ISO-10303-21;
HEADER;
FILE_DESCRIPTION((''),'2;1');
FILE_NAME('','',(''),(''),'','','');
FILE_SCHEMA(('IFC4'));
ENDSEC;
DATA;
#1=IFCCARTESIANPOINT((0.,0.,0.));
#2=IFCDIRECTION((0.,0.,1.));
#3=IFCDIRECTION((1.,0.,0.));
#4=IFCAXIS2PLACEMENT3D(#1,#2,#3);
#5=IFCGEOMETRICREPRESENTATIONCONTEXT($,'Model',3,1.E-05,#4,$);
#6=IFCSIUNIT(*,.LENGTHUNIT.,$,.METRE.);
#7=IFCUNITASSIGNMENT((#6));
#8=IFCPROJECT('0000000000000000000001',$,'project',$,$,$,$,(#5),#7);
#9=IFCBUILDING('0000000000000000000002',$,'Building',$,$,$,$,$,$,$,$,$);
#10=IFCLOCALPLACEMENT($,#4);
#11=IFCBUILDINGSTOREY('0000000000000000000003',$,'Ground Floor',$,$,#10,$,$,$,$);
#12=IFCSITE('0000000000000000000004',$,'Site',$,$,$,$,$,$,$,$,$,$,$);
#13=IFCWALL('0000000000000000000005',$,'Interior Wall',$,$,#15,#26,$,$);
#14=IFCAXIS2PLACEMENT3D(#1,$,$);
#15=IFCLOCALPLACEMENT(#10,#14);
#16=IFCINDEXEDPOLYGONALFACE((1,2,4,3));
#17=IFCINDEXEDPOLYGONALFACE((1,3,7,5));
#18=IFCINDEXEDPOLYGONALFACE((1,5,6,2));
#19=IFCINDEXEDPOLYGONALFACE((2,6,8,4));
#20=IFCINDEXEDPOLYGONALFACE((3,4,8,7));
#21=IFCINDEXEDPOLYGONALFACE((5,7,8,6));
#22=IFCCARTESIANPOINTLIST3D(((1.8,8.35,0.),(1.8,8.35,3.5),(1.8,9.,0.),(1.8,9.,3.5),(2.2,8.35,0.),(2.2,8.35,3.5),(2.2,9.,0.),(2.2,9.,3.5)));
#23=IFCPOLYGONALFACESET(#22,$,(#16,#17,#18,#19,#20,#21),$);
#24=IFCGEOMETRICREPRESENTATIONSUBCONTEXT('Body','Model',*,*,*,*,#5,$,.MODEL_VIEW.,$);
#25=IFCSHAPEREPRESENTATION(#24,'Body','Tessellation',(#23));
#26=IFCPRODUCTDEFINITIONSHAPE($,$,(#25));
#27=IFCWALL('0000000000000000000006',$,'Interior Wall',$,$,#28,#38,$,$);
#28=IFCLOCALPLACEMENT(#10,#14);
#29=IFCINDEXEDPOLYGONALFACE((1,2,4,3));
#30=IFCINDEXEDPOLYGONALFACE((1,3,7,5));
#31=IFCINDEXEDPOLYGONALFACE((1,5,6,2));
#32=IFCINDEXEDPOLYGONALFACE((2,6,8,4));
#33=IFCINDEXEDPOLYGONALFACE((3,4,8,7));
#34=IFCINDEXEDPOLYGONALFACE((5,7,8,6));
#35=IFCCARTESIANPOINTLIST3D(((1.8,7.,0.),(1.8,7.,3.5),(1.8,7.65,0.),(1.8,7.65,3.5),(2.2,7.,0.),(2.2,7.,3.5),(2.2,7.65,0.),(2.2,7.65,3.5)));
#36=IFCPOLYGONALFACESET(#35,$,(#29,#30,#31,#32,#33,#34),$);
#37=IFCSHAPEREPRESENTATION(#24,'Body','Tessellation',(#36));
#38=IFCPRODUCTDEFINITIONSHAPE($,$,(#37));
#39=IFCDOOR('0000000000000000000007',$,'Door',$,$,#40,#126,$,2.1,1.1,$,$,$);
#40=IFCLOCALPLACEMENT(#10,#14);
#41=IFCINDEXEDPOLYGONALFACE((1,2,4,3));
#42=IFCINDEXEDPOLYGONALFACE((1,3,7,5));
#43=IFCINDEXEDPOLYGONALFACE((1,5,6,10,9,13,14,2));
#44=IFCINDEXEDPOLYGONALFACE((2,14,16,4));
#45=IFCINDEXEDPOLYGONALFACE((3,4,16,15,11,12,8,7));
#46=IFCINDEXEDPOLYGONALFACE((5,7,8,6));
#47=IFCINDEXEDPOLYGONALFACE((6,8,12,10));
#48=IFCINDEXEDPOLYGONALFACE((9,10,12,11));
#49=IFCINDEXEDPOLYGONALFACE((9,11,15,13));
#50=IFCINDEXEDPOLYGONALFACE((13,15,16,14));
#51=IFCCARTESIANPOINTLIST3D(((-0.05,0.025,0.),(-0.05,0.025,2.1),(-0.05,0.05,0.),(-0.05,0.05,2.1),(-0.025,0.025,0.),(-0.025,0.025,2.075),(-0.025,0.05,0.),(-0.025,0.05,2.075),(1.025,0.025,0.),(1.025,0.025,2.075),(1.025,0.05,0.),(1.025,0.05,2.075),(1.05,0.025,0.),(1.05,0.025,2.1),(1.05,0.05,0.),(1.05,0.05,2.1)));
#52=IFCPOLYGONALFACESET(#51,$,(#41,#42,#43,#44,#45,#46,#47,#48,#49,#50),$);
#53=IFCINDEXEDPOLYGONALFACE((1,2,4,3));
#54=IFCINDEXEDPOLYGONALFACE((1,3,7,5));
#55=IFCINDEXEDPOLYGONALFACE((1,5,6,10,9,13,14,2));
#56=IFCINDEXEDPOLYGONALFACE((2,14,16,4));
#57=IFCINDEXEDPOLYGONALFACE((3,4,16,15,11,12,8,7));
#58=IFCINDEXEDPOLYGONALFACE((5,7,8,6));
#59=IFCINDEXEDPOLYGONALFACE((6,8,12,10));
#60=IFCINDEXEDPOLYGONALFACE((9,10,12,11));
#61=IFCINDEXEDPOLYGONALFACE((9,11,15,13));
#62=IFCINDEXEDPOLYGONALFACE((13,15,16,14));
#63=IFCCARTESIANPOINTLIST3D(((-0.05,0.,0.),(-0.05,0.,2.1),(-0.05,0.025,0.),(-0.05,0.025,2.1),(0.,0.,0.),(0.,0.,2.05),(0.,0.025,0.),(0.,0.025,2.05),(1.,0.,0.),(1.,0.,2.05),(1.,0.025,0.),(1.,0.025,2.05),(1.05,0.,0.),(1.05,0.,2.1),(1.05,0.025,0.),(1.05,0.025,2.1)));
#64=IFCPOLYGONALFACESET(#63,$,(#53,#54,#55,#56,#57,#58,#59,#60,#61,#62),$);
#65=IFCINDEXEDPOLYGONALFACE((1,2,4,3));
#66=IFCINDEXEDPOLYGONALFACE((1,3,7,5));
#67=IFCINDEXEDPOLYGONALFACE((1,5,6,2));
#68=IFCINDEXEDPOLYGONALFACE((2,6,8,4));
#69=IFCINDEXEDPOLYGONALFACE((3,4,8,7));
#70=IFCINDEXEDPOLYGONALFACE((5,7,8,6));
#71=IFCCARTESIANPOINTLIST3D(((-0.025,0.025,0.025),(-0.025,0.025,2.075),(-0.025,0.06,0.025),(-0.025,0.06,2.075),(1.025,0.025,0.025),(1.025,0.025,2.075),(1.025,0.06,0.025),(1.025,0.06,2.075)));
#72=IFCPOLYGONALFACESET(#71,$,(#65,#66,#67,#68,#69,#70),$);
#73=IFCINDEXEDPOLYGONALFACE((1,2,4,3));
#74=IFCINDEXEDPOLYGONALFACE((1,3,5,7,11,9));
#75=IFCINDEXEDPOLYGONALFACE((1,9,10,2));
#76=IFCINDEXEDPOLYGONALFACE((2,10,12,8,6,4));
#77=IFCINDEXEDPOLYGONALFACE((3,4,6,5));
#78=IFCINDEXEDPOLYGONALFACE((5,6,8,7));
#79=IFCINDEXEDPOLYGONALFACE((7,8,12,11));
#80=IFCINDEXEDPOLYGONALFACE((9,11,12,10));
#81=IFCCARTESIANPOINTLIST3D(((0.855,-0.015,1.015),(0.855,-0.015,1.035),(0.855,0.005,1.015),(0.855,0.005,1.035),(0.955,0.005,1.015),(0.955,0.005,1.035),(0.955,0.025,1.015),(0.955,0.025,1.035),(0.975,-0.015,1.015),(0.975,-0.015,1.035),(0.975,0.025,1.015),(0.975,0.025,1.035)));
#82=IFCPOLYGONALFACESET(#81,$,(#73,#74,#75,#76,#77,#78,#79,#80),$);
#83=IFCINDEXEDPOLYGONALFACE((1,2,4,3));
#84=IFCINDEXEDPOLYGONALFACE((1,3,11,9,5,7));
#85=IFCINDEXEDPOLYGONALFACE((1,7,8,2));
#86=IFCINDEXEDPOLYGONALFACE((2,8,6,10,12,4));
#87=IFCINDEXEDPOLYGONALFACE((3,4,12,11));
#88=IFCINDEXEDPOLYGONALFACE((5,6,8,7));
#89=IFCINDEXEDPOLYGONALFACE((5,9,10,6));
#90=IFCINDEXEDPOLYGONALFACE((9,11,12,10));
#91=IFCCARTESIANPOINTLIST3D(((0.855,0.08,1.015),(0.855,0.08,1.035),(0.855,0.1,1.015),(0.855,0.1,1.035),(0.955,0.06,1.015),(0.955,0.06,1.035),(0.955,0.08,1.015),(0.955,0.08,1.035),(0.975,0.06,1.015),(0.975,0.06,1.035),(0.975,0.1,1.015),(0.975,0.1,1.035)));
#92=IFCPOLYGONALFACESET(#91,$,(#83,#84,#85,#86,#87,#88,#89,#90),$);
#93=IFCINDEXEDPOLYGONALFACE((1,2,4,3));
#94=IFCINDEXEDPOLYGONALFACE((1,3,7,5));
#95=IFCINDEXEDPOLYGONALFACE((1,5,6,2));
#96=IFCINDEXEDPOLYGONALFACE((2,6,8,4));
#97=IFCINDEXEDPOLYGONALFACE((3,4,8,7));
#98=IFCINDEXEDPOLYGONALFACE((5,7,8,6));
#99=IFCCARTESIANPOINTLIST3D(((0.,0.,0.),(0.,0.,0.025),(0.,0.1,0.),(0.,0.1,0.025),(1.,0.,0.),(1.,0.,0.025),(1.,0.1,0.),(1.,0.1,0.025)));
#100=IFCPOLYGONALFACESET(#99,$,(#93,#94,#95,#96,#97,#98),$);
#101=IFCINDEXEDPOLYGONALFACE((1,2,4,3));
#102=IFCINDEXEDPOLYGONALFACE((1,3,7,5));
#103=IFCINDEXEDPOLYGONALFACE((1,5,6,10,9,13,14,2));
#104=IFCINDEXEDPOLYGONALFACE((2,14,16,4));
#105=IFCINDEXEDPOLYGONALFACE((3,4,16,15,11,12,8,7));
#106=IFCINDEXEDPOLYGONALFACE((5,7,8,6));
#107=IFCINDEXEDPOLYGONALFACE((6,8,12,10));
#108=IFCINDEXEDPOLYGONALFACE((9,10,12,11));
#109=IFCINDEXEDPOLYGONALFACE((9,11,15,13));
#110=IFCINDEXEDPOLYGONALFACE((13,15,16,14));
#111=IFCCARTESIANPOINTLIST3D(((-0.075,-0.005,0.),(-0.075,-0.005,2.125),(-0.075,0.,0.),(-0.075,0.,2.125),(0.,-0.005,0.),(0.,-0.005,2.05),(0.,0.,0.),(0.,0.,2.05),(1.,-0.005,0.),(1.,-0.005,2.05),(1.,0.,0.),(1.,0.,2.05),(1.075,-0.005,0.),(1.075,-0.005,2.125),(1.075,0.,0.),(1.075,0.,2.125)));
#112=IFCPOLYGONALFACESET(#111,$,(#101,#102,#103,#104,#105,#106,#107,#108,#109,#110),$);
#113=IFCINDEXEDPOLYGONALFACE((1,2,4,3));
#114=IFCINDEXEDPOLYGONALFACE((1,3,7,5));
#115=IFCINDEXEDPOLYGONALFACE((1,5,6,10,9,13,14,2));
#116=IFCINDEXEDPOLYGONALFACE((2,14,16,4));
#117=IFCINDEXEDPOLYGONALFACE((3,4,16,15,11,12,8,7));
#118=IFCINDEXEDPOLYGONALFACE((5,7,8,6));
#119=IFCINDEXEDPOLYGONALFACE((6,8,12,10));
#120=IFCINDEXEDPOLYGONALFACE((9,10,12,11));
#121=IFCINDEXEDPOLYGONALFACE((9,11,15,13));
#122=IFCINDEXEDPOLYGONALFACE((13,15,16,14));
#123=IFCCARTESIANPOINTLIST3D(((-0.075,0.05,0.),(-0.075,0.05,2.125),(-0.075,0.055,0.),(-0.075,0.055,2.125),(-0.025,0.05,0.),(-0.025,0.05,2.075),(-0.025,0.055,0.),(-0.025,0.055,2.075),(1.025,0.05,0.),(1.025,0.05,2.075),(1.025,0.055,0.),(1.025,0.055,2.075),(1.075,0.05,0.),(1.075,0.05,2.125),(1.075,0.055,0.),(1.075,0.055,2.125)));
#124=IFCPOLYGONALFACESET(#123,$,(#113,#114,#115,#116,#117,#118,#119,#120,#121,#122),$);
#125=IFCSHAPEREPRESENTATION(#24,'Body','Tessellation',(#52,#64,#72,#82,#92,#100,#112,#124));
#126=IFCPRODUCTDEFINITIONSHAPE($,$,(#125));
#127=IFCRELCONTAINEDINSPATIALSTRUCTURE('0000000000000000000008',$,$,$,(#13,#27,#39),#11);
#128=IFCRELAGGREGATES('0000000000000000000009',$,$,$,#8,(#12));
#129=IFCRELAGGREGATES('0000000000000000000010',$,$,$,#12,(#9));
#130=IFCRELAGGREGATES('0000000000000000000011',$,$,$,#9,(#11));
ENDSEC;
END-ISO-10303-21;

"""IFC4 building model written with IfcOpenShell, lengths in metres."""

from ifc_helpers import new_model, si_unit, frame, origin_with_axes, place, context, subcontext, project, spatial, line, indexed_curve, outline, extrude, element, save


model = new_model("IFC4")

# Units and contexts
model_context = context("Model", 3, precision=1e-05, world=origin_with_axes())
body_context = subcontext(model_context, "Body", "Model", "MODEL_VIEW")
ifc_project = project(units=[si_unit("LENGTHUNIT", "METRE")], contexts=[model_context])

# Site, building, storey
site = spatial("IfcSite", under=ifc_project, Name="Site")
building = spatial("IfcBuilding", under=site, Name="Building")
storey_placement = place(None, origin_with_axes())
storey = spatial("IfcBuildingStorey", under=building, at=storey_placement, Name="Ground Floor")

# Walls
for number, where, z_axis, x_axis, name in (
    (1, (2.0, 9.0, 0.0), (0.0, 0.0, 1.0), (0.0, -1.0, 0.0), "Interior Wall"),
    (2, (2.0, 7.65, 0.0), (0.0, 0.0, 1.0), (0.0, -1.0, 0.0), "Interior Wall"),
):
    element("IfcWall", number, at=place(storey_placement, frame(where, z_axis=z_axis, x_axis=x_axis)), inside=storey, Name=name, context=body_context, shape_type="SweptSolid", body=[
        extrude(outline(indexed_curve([(0.0, 0.0), (0.0, 0.4), (0.65, 0.4), (0.65, 0.0), (0.0, 0.0)], self_intersect=False)), frame((0.0, -0.2, 0.0), z_axis=(0.0, 0.0, 1.0), x_axis=(1.0, 0.0, 0.0)), (0.0, 0.0, 1.0), 3.5),
    ])

# Door
door_1_placement = place(storey_placement, frame((-0.05, 0.0, 0.0), z_axis=(0.0, 0.0, 1.0), x_axis=(1.0, 0.0, 0.0)))
element("IfcDoor", 3, at=door_1_placement, inside=storey, Name="Door", OverallHeight=2.1, OverallWidth=1.1, context=body_context, shape_type="SweptSolid", body=[
    extrude(outline(indexed_curve([(0.0, 0.0), (0.0, 2.1), (1.1, 2.1), (1.1, 0.0), (1.075, 0.0), (1.075, 2.075), (0.025, 2.075), (0.025, 0.0)], segments=[line(1, 2, 3, 4, 5, 6, 7, 8, 1)])), frame((0.0, 0.025, 0.0), z_axis=(0.0, -1.0, 0.0), x_axis=(1.0, 0.0, 0.0)), (0.0, 0.0, -1.0), 0.025),
    extrude(outline(indexed_curve([(0.0, 0.0), (0.0, 2.1), (1.1, 2.1), (1.1, 0.0), (1.05, 0.0), (1.05, 2.05), (0.05, 2.05), (0.05, 0.0)], segments=[line(1, 2, 3, 4, 5, 6, 7, 8, 1)])), frame((0.0, 0.0, 0.0), z_axis=(0.0, -1.0, 0.0), x_axis=(1.0, 0.0, 0.0)), (0.0, 0.0, -1.0), 0.025),
    extrude(outline(indexed_curve([(0.0, 0.0), (1.05, 0.0), (1.05, 0.035), (0.0, 0.035)], segments=[line(1, 2, 3, 4, 1)])), frame((0.025, 0.025, 0.025), z_axis=(0.0, 0.0, 1.0), x_axis=(1.0, 0.0, 0.0)), (0.0, 0.0, 1.0), 2.05),
    extrude(outline(indexed_curve([(0.0, 0.0), (0.0, -0.04), (-0.12, -0.04), (-0.12, -0.02), (-0.02, -0.02), (-0.02, 0.0)], segments=[line(1, 2, 3, 4, 5, 6, 1)])), frame((1.025, 0.025, 1.015), z_axis=(0.0, 0.0, 1.0), x_axis=(1.0, 0.0, 0.0)), (0.0, 0.0, 1.0), 0.02),
    extrude(outline(indexed_curve([(0.0, 0.0), (0.0, 0.04), (-0.12, 0.04), (-0.12, 0.02), (-0.02, 0.02), (-0.02, 0.0)], segments=[line(1, 2, 3, 4, 5, 6, 1)])), frame((1.025, 0.06, 1.015), z_axis=(0.0, 0.0, 1.0), x_axis=(1.0, 0.0, 0.0)), (0.0, 0.0, 1.0), 0.02),
    extrude(outline(indexed_curve([(0.0, 0.0), (1.0, 0.0), (1.0, 0.1), (0.0, 0.1)], segments=[line(1, 2, 3, 4, 1)])), frame((0.05, 0.0, 0.0), z_axis=(0.0, 0.0, 1.0), x_axis=(1.0, 0.0, 0.0)), (0.0, 0.0, 1.0), 0.025),
    extrude(outline(indexed_curve([(0.0, 0.0), (0.0, 2.125), (1.15, 2.125), (1.15, 0.0), (1.075, 0.0), (1.075, 2.05), (0.075, 2.05), (0.075, 0.0)], segments=[line(1, 2, 3, 4, 5, 6, 7, 8, 1)])), frame((-0.025, -0.005, 0.0), z_axis=(0.0, -1.0, 0.0), x_axis=(1.0, 0.0, 0.0)), (0.0, 0.0, -1.0), 0.005),
    extrude(outline(indexed_curve([(0.0, 0.0), (0.0, 2.125), (1.15, 2.125), (1.15, 0.0), (1.1, 0.0), (1.1, 2.075), (0.05, 2.075), (0.05, 0.0)], segments=[line(1, 2, 3, 4, 5, 6, 7, 8, 1)])), frame((-0.025, 0.05, 0.0), z_axis=(0.0, -1.0, 0.0), x_axis=(1.0, 0.0, 0.0)), (0.0, 0.0, -1.0), 0.005),
])

save(model, "model.ifc")
